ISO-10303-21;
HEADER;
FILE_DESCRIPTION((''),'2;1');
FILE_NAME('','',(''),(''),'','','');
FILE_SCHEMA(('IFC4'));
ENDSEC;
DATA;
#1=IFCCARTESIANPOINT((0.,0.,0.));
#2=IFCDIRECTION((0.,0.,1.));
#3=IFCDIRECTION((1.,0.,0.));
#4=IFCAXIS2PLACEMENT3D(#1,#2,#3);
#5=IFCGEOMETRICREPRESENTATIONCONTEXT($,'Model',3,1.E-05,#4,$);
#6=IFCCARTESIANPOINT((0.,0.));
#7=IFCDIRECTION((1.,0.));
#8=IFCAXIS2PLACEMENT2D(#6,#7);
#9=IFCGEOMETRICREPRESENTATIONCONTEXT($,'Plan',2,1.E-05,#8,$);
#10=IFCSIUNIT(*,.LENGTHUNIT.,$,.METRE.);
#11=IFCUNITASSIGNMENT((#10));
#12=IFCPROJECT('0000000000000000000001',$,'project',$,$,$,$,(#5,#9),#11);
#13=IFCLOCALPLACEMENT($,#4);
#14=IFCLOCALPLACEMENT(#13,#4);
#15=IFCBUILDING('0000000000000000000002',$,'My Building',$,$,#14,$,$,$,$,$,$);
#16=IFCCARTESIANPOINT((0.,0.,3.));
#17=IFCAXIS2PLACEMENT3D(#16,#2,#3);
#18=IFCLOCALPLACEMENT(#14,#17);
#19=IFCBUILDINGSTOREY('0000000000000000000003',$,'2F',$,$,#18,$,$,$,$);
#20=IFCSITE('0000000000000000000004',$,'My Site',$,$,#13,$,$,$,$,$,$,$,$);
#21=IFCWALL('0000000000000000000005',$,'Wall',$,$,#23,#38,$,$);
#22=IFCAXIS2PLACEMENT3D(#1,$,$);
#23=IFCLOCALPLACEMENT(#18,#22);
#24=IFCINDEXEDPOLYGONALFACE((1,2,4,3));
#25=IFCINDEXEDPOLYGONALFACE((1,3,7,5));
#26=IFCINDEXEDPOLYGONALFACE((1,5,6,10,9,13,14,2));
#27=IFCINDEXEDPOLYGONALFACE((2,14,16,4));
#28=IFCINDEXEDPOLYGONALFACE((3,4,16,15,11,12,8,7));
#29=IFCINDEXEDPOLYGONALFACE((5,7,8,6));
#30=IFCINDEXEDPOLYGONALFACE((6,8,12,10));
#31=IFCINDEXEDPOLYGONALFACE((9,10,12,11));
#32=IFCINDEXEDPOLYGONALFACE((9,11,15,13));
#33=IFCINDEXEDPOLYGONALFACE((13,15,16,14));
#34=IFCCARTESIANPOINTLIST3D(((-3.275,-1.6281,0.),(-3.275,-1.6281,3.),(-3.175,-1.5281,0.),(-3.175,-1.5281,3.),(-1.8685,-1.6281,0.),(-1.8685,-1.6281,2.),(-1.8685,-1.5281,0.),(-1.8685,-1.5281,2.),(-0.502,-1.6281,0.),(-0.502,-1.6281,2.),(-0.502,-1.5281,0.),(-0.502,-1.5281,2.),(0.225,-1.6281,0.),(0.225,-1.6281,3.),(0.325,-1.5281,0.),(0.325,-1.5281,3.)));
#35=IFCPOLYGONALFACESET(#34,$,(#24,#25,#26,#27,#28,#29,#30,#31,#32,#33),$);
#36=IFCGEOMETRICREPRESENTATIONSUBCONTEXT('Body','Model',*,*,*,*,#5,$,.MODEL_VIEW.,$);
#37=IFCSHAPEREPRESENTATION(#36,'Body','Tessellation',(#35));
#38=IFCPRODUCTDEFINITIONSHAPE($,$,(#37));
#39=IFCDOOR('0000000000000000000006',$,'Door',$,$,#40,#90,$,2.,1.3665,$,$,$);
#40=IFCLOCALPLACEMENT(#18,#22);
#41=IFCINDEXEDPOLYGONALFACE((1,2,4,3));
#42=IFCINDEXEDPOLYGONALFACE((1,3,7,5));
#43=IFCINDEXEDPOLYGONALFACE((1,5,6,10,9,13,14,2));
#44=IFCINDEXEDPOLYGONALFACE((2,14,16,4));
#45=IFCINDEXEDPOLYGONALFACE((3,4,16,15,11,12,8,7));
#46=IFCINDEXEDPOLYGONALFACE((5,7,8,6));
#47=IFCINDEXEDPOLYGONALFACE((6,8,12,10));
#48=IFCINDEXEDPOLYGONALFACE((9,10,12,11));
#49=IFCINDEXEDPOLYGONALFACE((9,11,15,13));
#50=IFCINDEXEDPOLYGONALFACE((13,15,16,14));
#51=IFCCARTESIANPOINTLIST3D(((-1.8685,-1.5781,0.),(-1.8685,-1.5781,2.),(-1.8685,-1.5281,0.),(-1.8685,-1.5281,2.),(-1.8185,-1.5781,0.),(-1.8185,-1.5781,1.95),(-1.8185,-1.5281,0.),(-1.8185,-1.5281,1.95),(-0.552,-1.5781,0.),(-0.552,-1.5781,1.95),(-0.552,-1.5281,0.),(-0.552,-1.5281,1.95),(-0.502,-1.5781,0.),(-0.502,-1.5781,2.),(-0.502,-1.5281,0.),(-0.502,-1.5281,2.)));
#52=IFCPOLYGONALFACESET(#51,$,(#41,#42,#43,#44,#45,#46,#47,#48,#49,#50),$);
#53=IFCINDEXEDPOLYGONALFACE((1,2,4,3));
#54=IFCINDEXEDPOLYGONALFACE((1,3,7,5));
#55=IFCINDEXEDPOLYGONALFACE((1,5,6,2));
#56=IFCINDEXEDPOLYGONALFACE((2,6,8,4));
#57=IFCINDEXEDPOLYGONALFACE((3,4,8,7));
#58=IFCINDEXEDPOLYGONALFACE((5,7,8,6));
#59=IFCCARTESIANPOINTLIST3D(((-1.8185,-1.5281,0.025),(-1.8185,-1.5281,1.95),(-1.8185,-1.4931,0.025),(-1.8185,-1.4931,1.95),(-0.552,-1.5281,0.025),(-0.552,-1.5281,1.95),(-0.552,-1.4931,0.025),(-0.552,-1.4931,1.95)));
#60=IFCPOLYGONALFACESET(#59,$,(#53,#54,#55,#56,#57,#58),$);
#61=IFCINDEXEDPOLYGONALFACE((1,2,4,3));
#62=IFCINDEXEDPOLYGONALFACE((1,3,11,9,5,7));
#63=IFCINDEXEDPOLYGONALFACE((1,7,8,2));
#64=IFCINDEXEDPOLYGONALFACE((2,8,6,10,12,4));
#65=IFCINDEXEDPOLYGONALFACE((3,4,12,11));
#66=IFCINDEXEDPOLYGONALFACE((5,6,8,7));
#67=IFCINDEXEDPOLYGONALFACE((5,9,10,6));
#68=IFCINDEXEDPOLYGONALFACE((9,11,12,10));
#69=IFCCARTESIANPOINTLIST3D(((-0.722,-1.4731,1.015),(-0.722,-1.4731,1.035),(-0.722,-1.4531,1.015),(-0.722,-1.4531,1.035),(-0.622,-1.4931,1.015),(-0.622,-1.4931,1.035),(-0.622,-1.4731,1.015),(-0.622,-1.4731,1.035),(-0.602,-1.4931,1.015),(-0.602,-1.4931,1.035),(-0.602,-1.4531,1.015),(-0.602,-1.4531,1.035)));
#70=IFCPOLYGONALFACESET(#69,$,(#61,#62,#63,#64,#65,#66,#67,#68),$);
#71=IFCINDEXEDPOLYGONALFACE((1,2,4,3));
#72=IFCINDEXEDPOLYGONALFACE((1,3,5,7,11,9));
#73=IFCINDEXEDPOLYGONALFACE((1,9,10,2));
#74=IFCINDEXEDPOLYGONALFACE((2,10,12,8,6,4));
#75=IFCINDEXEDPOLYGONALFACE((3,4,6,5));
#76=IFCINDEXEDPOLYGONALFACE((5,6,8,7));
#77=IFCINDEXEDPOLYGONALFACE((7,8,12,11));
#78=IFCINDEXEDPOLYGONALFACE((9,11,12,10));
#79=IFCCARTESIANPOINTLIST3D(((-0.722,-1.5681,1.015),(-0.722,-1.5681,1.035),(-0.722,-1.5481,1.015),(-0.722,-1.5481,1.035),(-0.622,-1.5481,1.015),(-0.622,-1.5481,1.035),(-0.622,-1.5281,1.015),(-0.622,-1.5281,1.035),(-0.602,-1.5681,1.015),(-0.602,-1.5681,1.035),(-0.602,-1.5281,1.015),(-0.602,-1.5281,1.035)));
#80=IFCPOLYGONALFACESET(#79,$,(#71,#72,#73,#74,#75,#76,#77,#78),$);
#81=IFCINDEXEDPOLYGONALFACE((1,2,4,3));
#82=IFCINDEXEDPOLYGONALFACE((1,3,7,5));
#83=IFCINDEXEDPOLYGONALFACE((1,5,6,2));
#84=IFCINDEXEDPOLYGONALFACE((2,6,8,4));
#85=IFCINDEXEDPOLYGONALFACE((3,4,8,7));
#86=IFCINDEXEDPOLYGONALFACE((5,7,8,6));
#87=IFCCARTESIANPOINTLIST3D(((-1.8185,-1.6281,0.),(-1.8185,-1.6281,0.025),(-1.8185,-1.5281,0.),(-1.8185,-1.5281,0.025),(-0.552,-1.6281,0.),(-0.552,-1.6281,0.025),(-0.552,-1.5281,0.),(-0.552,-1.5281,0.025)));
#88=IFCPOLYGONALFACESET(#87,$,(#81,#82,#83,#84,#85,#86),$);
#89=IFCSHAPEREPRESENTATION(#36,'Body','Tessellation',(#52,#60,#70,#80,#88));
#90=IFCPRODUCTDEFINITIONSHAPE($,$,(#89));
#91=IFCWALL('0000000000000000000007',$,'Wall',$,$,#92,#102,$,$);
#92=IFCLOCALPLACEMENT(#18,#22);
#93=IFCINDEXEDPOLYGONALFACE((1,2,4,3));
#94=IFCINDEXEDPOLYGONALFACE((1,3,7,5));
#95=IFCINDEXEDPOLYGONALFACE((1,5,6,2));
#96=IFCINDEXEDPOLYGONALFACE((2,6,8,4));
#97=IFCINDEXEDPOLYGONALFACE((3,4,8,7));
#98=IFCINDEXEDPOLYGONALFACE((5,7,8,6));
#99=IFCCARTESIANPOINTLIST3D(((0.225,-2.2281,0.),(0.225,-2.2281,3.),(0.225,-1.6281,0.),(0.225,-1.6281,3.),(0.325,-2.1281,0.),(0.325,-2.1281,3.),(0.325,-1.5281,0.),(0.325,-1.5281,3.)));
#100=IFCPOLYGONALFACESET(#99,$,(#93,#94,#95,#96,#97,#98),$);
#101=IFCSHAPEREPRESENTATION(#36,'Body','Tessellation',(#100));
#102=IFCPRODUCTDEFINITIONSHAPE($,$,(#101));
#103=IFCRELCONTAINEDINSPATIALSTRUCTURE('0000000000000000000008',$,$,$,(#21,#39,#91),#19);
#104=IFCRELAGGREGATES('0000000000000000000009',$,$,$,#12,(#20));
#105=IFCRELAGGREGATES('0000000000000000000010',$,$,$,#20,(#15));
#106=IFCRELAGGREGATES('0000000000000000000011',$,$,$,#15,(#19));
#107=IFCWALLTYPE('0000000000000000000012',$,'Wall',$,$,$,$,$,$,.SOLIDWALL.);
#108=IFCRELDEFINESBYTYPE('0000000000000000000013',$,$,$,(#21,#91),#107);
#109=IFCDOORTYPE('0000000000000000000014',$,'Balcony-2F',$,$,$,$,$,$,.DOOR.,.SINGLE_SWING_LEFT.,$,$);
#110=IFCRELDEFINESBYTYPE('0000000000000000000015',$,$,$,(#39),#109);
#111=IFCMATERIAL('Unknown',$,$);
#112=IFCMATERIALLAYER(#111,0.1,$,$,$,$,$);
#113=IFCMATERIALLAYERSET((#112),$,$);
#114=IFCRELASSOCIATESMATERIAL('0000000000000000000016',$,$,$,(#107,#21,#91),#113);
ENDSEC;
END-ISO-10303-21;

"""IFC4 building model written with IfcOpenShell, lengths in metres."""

from ifc_helpers import new_model, entity, si_unit, frame, origin_with_axes, origin_2d_with_axis, place, context, subcontext, project, spatial, line, indexed_curve, outline, extrude, shape, source, transform, mapped, material, layer, layer_set, layer_usage, type_object, type_shapes, element, fill, save


model = new_model("IFC4")

# Units and contexts
model_context = context("Model", 3, precision=1e-05, world=origin_with_axes())
plan_context = context("Plan", 2, precision=1e-05, world=origin_2d_with_axis())
body_context_1 = subcontext(model_context, "Body", "Model", "MODEL_VIEW")
body_context_2 = subcontext(plan_context, "Body", "Plan", "PLAN_VIEW")
ifc_project = project(units=[si_unit("LENGTHUNIT", "METRE")], contexts=[model_context, plan_context])

# Site, building, storey
site_placement = place(None, origin_with_axes())
site = spatial("IfcSite", under=ifc_project, at=site_placement, Name="My Site")
building_placement = place(site_placement, origin_with_axes())
building = spatial("IfcBuilding", under=site, at=building_placement, Name="My Building")
storey_placement = place(building_placement, frame((0.0, 0.0, 3.0), z_axis=(0.0, 0.0, 1.0), x_axis=(1.0, 0.0, 0.0)))
storey = spatial("IfcBuildingStorey", under=building, at=storey_placement, Name="2F")

# Shared definitions
ifc_material = material(Name="Unknown")

# Shared definitions
ifc_layer_1 = layer(ifc_material, 0.1)
ifc_layer_set_1 = layer_set([ifc_layer_1])
wall_type = type_object("IfcWallType", Name="Wall", PredefinedType="SOLIDWALL", material=ifc_layer_set_1)

# Wall, opening, door
ifc_layer_usage_1 = layer_usage(ifc_layer_set_1, "AXIS2", "POSITIVE", 0.0)
wall_1_placement = place(storey_placement, frame((-3.275, -1.6281, 0.0), z_axis=(0.0, 0.0, 1.0), x_axis=(1.0, 0.0, 0.0)))
wall_1 = element("IfcWall", 1, at=wall_1_placement, inside=storey, type_object=wall_type, material=ifc_layer_usage_1, Name="Wall", context=body_context_1, shape_type="SweptSolid", body=[
    extrude(outline(indexed_curve([(0.0, 0.0), (0.1, 0.1), (3.6, 0.1), (3.5, 0.0)], segments=[line(1, 2, 3, 4, 1)])), origin_with_axes(), (0.0, 0.0, 1.0), 3.0),
])
shared_shape_1 = source(origin_with_axes(), body_context_1, "Body", "SweptSolid", [
    extrude(outline(indexed_curve([(0.0, 0.0), (1.3665, 0.0), (1.3665, 2.0), (0.0, 2.0)], segments=[line(1, 2, 3, 4, 1)])), frame((0.0, -0.6, 0.0), z_axis=(0.0, -1.0, 0.0), x_axis=(1.0, 0.0, 0.0)), (0.0, 0.0, -1.0), 1.2),
])
opening_1_placement = place(wall_1_placement, frame((2.773, 0.1, 0.0), z_axis=(0.0, 0.0, 1.0), x_axis=(-1.0, 0.0, 0.0)))
opening_1 = element("IfcOpeningElement", 2, at=opening_1_placement, cuts=wall_1, PredefinedType="OPENING", context=body_context_1, shape_type="MappedRepresentation", body=[
    mapped(shared_shape_1, transform((0.0, 0.0, 0.0), x_axis=(1.0, 0.0, 0.0), y_axis=(0.0, 1.0, 0.0), z_axis=(0.0, 0.0, 1.0), scale=1.0)),
])
door_type_1 = type_object("IfcDoorType", Name="Balcony-2F", OperationType="SINGLE_SWING_LEFT", PredefinedType="DOOR")
shared_shape_2 = source(origin_with_axes(), body_context_1, "Body", "SweptSolid", [
    extrude(outline(indexed_curve([(0.0, 0.0), (0.0, 2.0), (1.3665, 2.0), (1.3665, 0.0), (1.3165, 0.0), (1.3165, 1.95), (0.05, 1.95), (0.05, 0.0)], segments=[line(1, 2, 3, 4, 5, 6, 7, 8, 1)])), frame((0.0, 0.0, 0.0), z_axis=(0.0, -1.0, 0.0), x_axis=(1.0, 0.0, 0.0)), (0.0, 0.0, -1.0), 0.05),
    extrude(outline(indexed_curve([(0.0, 0.0), (1.2665, 0.0), (1.2665, 0.035), (0.0, 0.035)], segments=[line(1, 2, 3, 4, 1)])), frame((0.05, -0.035, 0.025), z_axis=(0.0, 0.0, 1.0), x_axis=(1.0, 0.0, 0.0)), (0.0, 0.0, 1.0), 1.925),
    extrude(outline(indexed_curve([(0.0, 0.0), (0.0, -0.04), (0.12, -0.04), (0.12, -0.02), (0.02, -0.02), (0.02, 0.0)], segments=[line(1, 2, 3, 4, 5, 6, 1)])), frame((0.1, -0.035, 1.015), z_axis=(0.0, 0.0, 1.0), x_axis=(1.0, 0.0, 0.0)), (0.0, 0.0, 1.0), 0.02),
    extrude(outline(indexed_curve([(0.0, 0.0), (0.0, 0.04), (0.12, 0.04), (0.12, 0.02), (0.02, 0.02), (0.02, 0.0)], segments=[line(1, 2, 3, 4, 5, 6, 1)])), frame((0.1, 0.0, 1.015), z_axis=(0.0, 0.0, 1.0), x_axis=(1.0, 0.0, 0.0)), (0.0, 0.0, 1.0), 0.02),
    extrude(outline(indexed_curve([(0.0, 0.0), (1.2665, 0.0), (1.2665, 0.1), (0.0, 0.1)], segments=[line(1, 2, 3, 4, 1)])), frame((0.05, 0.0, 0.0), z_axis=(0.0, 0.0, 1.0), x_axis=(1.0, 0.0, 0.0)), (0.0, 0.0, 1.0), 0.025),
])
shared_shape_3 = source(origin_with_axes(), body_context_2, "Body", "Curve2D", [
    entity("IfcIndexedPolyCurve", entity("IfcCartesianPointList2D", [[0.0, 0.0], [0.05, 0.0], [0.05, 0.05], [0.0, 0.05]]), [entity("IfcLineIndex", [1, 2, 3, 4, 1])]),
    entity("IfcIndexedPolyCurve", entity("IfcCartesianPointList2D", [[1.3665, 0.0], [1.3165, 0.0], [1.3165, 0.05], [1.3665, 0.05]]), [entity("IfcLineIndex", [1, 2, 3, 4, 1])]),
    entity("IfcIndexedPolyCurve", entity("IfcCartesianPointList2D", [[1.9498, -0.035], [0.6833, -0.035], [0.6833, 0.0], [1.9498, 0.0]]), [entity("IfcLineIndex", [1, 2, 3, 4, 1])]),
])
type_shapes(door_type_1, [shared_shape_2, shared_shape_3])
door_1_placement = place(opening_1_placement, origin_with_axes())
door_1 = element("IfcDoor", 3, at=door_1_placement, inside=storey, type_object=door_type_1, Name="Door", OverallHeight=2.0, OverallWidth=1.3665, shapes=[
    shape(body_context_1, "Body", "MappedRepresentation", [mapped(shared_shape_2, transform((0.0, 0.0, 0.0), x_axis=(1.0, 0.0, 0.0), y_axis=(0.0, 1.0, 0.0), z_axis=(0.0, 0.0, 1.0), scale=1.0))]),
    shape(body_context_2, "Body", "MappedRepresentation", [mapped(shared_shape_3, transform((0.0, 0.0, 0.0), x_axis=(1.0, 0.0, 0.0), y_axis=(0.0, 1.0, 0.0), z_axis=(0.0, 0.0, 1.0), scale=1.0))]),
])
fill(opening_1, door_1)

# Wall
ifc_layer_usage_2 = layer_usage(ifc_layer_set_1, "AXIS2", "POSITIVE", 0.0)
wall_2_placement = place(storey_placement, frame((0.225, -1.6281, 0.0), z_axis=(0.0, 0.0, 1.0), x_axis=(0.0, -1.0, 0.0)))
element("IfcWall", 4, at=wall_2_placement, inside=storey, type_object=wall_type, material=ifc_layer_usage_2, Name="Wall", context=body_context_1, shape_type="SweptSolid", body=[
    extrude(outline(indexed_curve([(0.0, 0.0), (-0.1, 0.1), (0.5, 0.1), (0.6, 0.0)], segments=[line(1, 2, 3, 4, 1)])), origin_with_axes(), (0.0, 0.0, 1.0), 3.0),
])

save(model, "model.ifc")
